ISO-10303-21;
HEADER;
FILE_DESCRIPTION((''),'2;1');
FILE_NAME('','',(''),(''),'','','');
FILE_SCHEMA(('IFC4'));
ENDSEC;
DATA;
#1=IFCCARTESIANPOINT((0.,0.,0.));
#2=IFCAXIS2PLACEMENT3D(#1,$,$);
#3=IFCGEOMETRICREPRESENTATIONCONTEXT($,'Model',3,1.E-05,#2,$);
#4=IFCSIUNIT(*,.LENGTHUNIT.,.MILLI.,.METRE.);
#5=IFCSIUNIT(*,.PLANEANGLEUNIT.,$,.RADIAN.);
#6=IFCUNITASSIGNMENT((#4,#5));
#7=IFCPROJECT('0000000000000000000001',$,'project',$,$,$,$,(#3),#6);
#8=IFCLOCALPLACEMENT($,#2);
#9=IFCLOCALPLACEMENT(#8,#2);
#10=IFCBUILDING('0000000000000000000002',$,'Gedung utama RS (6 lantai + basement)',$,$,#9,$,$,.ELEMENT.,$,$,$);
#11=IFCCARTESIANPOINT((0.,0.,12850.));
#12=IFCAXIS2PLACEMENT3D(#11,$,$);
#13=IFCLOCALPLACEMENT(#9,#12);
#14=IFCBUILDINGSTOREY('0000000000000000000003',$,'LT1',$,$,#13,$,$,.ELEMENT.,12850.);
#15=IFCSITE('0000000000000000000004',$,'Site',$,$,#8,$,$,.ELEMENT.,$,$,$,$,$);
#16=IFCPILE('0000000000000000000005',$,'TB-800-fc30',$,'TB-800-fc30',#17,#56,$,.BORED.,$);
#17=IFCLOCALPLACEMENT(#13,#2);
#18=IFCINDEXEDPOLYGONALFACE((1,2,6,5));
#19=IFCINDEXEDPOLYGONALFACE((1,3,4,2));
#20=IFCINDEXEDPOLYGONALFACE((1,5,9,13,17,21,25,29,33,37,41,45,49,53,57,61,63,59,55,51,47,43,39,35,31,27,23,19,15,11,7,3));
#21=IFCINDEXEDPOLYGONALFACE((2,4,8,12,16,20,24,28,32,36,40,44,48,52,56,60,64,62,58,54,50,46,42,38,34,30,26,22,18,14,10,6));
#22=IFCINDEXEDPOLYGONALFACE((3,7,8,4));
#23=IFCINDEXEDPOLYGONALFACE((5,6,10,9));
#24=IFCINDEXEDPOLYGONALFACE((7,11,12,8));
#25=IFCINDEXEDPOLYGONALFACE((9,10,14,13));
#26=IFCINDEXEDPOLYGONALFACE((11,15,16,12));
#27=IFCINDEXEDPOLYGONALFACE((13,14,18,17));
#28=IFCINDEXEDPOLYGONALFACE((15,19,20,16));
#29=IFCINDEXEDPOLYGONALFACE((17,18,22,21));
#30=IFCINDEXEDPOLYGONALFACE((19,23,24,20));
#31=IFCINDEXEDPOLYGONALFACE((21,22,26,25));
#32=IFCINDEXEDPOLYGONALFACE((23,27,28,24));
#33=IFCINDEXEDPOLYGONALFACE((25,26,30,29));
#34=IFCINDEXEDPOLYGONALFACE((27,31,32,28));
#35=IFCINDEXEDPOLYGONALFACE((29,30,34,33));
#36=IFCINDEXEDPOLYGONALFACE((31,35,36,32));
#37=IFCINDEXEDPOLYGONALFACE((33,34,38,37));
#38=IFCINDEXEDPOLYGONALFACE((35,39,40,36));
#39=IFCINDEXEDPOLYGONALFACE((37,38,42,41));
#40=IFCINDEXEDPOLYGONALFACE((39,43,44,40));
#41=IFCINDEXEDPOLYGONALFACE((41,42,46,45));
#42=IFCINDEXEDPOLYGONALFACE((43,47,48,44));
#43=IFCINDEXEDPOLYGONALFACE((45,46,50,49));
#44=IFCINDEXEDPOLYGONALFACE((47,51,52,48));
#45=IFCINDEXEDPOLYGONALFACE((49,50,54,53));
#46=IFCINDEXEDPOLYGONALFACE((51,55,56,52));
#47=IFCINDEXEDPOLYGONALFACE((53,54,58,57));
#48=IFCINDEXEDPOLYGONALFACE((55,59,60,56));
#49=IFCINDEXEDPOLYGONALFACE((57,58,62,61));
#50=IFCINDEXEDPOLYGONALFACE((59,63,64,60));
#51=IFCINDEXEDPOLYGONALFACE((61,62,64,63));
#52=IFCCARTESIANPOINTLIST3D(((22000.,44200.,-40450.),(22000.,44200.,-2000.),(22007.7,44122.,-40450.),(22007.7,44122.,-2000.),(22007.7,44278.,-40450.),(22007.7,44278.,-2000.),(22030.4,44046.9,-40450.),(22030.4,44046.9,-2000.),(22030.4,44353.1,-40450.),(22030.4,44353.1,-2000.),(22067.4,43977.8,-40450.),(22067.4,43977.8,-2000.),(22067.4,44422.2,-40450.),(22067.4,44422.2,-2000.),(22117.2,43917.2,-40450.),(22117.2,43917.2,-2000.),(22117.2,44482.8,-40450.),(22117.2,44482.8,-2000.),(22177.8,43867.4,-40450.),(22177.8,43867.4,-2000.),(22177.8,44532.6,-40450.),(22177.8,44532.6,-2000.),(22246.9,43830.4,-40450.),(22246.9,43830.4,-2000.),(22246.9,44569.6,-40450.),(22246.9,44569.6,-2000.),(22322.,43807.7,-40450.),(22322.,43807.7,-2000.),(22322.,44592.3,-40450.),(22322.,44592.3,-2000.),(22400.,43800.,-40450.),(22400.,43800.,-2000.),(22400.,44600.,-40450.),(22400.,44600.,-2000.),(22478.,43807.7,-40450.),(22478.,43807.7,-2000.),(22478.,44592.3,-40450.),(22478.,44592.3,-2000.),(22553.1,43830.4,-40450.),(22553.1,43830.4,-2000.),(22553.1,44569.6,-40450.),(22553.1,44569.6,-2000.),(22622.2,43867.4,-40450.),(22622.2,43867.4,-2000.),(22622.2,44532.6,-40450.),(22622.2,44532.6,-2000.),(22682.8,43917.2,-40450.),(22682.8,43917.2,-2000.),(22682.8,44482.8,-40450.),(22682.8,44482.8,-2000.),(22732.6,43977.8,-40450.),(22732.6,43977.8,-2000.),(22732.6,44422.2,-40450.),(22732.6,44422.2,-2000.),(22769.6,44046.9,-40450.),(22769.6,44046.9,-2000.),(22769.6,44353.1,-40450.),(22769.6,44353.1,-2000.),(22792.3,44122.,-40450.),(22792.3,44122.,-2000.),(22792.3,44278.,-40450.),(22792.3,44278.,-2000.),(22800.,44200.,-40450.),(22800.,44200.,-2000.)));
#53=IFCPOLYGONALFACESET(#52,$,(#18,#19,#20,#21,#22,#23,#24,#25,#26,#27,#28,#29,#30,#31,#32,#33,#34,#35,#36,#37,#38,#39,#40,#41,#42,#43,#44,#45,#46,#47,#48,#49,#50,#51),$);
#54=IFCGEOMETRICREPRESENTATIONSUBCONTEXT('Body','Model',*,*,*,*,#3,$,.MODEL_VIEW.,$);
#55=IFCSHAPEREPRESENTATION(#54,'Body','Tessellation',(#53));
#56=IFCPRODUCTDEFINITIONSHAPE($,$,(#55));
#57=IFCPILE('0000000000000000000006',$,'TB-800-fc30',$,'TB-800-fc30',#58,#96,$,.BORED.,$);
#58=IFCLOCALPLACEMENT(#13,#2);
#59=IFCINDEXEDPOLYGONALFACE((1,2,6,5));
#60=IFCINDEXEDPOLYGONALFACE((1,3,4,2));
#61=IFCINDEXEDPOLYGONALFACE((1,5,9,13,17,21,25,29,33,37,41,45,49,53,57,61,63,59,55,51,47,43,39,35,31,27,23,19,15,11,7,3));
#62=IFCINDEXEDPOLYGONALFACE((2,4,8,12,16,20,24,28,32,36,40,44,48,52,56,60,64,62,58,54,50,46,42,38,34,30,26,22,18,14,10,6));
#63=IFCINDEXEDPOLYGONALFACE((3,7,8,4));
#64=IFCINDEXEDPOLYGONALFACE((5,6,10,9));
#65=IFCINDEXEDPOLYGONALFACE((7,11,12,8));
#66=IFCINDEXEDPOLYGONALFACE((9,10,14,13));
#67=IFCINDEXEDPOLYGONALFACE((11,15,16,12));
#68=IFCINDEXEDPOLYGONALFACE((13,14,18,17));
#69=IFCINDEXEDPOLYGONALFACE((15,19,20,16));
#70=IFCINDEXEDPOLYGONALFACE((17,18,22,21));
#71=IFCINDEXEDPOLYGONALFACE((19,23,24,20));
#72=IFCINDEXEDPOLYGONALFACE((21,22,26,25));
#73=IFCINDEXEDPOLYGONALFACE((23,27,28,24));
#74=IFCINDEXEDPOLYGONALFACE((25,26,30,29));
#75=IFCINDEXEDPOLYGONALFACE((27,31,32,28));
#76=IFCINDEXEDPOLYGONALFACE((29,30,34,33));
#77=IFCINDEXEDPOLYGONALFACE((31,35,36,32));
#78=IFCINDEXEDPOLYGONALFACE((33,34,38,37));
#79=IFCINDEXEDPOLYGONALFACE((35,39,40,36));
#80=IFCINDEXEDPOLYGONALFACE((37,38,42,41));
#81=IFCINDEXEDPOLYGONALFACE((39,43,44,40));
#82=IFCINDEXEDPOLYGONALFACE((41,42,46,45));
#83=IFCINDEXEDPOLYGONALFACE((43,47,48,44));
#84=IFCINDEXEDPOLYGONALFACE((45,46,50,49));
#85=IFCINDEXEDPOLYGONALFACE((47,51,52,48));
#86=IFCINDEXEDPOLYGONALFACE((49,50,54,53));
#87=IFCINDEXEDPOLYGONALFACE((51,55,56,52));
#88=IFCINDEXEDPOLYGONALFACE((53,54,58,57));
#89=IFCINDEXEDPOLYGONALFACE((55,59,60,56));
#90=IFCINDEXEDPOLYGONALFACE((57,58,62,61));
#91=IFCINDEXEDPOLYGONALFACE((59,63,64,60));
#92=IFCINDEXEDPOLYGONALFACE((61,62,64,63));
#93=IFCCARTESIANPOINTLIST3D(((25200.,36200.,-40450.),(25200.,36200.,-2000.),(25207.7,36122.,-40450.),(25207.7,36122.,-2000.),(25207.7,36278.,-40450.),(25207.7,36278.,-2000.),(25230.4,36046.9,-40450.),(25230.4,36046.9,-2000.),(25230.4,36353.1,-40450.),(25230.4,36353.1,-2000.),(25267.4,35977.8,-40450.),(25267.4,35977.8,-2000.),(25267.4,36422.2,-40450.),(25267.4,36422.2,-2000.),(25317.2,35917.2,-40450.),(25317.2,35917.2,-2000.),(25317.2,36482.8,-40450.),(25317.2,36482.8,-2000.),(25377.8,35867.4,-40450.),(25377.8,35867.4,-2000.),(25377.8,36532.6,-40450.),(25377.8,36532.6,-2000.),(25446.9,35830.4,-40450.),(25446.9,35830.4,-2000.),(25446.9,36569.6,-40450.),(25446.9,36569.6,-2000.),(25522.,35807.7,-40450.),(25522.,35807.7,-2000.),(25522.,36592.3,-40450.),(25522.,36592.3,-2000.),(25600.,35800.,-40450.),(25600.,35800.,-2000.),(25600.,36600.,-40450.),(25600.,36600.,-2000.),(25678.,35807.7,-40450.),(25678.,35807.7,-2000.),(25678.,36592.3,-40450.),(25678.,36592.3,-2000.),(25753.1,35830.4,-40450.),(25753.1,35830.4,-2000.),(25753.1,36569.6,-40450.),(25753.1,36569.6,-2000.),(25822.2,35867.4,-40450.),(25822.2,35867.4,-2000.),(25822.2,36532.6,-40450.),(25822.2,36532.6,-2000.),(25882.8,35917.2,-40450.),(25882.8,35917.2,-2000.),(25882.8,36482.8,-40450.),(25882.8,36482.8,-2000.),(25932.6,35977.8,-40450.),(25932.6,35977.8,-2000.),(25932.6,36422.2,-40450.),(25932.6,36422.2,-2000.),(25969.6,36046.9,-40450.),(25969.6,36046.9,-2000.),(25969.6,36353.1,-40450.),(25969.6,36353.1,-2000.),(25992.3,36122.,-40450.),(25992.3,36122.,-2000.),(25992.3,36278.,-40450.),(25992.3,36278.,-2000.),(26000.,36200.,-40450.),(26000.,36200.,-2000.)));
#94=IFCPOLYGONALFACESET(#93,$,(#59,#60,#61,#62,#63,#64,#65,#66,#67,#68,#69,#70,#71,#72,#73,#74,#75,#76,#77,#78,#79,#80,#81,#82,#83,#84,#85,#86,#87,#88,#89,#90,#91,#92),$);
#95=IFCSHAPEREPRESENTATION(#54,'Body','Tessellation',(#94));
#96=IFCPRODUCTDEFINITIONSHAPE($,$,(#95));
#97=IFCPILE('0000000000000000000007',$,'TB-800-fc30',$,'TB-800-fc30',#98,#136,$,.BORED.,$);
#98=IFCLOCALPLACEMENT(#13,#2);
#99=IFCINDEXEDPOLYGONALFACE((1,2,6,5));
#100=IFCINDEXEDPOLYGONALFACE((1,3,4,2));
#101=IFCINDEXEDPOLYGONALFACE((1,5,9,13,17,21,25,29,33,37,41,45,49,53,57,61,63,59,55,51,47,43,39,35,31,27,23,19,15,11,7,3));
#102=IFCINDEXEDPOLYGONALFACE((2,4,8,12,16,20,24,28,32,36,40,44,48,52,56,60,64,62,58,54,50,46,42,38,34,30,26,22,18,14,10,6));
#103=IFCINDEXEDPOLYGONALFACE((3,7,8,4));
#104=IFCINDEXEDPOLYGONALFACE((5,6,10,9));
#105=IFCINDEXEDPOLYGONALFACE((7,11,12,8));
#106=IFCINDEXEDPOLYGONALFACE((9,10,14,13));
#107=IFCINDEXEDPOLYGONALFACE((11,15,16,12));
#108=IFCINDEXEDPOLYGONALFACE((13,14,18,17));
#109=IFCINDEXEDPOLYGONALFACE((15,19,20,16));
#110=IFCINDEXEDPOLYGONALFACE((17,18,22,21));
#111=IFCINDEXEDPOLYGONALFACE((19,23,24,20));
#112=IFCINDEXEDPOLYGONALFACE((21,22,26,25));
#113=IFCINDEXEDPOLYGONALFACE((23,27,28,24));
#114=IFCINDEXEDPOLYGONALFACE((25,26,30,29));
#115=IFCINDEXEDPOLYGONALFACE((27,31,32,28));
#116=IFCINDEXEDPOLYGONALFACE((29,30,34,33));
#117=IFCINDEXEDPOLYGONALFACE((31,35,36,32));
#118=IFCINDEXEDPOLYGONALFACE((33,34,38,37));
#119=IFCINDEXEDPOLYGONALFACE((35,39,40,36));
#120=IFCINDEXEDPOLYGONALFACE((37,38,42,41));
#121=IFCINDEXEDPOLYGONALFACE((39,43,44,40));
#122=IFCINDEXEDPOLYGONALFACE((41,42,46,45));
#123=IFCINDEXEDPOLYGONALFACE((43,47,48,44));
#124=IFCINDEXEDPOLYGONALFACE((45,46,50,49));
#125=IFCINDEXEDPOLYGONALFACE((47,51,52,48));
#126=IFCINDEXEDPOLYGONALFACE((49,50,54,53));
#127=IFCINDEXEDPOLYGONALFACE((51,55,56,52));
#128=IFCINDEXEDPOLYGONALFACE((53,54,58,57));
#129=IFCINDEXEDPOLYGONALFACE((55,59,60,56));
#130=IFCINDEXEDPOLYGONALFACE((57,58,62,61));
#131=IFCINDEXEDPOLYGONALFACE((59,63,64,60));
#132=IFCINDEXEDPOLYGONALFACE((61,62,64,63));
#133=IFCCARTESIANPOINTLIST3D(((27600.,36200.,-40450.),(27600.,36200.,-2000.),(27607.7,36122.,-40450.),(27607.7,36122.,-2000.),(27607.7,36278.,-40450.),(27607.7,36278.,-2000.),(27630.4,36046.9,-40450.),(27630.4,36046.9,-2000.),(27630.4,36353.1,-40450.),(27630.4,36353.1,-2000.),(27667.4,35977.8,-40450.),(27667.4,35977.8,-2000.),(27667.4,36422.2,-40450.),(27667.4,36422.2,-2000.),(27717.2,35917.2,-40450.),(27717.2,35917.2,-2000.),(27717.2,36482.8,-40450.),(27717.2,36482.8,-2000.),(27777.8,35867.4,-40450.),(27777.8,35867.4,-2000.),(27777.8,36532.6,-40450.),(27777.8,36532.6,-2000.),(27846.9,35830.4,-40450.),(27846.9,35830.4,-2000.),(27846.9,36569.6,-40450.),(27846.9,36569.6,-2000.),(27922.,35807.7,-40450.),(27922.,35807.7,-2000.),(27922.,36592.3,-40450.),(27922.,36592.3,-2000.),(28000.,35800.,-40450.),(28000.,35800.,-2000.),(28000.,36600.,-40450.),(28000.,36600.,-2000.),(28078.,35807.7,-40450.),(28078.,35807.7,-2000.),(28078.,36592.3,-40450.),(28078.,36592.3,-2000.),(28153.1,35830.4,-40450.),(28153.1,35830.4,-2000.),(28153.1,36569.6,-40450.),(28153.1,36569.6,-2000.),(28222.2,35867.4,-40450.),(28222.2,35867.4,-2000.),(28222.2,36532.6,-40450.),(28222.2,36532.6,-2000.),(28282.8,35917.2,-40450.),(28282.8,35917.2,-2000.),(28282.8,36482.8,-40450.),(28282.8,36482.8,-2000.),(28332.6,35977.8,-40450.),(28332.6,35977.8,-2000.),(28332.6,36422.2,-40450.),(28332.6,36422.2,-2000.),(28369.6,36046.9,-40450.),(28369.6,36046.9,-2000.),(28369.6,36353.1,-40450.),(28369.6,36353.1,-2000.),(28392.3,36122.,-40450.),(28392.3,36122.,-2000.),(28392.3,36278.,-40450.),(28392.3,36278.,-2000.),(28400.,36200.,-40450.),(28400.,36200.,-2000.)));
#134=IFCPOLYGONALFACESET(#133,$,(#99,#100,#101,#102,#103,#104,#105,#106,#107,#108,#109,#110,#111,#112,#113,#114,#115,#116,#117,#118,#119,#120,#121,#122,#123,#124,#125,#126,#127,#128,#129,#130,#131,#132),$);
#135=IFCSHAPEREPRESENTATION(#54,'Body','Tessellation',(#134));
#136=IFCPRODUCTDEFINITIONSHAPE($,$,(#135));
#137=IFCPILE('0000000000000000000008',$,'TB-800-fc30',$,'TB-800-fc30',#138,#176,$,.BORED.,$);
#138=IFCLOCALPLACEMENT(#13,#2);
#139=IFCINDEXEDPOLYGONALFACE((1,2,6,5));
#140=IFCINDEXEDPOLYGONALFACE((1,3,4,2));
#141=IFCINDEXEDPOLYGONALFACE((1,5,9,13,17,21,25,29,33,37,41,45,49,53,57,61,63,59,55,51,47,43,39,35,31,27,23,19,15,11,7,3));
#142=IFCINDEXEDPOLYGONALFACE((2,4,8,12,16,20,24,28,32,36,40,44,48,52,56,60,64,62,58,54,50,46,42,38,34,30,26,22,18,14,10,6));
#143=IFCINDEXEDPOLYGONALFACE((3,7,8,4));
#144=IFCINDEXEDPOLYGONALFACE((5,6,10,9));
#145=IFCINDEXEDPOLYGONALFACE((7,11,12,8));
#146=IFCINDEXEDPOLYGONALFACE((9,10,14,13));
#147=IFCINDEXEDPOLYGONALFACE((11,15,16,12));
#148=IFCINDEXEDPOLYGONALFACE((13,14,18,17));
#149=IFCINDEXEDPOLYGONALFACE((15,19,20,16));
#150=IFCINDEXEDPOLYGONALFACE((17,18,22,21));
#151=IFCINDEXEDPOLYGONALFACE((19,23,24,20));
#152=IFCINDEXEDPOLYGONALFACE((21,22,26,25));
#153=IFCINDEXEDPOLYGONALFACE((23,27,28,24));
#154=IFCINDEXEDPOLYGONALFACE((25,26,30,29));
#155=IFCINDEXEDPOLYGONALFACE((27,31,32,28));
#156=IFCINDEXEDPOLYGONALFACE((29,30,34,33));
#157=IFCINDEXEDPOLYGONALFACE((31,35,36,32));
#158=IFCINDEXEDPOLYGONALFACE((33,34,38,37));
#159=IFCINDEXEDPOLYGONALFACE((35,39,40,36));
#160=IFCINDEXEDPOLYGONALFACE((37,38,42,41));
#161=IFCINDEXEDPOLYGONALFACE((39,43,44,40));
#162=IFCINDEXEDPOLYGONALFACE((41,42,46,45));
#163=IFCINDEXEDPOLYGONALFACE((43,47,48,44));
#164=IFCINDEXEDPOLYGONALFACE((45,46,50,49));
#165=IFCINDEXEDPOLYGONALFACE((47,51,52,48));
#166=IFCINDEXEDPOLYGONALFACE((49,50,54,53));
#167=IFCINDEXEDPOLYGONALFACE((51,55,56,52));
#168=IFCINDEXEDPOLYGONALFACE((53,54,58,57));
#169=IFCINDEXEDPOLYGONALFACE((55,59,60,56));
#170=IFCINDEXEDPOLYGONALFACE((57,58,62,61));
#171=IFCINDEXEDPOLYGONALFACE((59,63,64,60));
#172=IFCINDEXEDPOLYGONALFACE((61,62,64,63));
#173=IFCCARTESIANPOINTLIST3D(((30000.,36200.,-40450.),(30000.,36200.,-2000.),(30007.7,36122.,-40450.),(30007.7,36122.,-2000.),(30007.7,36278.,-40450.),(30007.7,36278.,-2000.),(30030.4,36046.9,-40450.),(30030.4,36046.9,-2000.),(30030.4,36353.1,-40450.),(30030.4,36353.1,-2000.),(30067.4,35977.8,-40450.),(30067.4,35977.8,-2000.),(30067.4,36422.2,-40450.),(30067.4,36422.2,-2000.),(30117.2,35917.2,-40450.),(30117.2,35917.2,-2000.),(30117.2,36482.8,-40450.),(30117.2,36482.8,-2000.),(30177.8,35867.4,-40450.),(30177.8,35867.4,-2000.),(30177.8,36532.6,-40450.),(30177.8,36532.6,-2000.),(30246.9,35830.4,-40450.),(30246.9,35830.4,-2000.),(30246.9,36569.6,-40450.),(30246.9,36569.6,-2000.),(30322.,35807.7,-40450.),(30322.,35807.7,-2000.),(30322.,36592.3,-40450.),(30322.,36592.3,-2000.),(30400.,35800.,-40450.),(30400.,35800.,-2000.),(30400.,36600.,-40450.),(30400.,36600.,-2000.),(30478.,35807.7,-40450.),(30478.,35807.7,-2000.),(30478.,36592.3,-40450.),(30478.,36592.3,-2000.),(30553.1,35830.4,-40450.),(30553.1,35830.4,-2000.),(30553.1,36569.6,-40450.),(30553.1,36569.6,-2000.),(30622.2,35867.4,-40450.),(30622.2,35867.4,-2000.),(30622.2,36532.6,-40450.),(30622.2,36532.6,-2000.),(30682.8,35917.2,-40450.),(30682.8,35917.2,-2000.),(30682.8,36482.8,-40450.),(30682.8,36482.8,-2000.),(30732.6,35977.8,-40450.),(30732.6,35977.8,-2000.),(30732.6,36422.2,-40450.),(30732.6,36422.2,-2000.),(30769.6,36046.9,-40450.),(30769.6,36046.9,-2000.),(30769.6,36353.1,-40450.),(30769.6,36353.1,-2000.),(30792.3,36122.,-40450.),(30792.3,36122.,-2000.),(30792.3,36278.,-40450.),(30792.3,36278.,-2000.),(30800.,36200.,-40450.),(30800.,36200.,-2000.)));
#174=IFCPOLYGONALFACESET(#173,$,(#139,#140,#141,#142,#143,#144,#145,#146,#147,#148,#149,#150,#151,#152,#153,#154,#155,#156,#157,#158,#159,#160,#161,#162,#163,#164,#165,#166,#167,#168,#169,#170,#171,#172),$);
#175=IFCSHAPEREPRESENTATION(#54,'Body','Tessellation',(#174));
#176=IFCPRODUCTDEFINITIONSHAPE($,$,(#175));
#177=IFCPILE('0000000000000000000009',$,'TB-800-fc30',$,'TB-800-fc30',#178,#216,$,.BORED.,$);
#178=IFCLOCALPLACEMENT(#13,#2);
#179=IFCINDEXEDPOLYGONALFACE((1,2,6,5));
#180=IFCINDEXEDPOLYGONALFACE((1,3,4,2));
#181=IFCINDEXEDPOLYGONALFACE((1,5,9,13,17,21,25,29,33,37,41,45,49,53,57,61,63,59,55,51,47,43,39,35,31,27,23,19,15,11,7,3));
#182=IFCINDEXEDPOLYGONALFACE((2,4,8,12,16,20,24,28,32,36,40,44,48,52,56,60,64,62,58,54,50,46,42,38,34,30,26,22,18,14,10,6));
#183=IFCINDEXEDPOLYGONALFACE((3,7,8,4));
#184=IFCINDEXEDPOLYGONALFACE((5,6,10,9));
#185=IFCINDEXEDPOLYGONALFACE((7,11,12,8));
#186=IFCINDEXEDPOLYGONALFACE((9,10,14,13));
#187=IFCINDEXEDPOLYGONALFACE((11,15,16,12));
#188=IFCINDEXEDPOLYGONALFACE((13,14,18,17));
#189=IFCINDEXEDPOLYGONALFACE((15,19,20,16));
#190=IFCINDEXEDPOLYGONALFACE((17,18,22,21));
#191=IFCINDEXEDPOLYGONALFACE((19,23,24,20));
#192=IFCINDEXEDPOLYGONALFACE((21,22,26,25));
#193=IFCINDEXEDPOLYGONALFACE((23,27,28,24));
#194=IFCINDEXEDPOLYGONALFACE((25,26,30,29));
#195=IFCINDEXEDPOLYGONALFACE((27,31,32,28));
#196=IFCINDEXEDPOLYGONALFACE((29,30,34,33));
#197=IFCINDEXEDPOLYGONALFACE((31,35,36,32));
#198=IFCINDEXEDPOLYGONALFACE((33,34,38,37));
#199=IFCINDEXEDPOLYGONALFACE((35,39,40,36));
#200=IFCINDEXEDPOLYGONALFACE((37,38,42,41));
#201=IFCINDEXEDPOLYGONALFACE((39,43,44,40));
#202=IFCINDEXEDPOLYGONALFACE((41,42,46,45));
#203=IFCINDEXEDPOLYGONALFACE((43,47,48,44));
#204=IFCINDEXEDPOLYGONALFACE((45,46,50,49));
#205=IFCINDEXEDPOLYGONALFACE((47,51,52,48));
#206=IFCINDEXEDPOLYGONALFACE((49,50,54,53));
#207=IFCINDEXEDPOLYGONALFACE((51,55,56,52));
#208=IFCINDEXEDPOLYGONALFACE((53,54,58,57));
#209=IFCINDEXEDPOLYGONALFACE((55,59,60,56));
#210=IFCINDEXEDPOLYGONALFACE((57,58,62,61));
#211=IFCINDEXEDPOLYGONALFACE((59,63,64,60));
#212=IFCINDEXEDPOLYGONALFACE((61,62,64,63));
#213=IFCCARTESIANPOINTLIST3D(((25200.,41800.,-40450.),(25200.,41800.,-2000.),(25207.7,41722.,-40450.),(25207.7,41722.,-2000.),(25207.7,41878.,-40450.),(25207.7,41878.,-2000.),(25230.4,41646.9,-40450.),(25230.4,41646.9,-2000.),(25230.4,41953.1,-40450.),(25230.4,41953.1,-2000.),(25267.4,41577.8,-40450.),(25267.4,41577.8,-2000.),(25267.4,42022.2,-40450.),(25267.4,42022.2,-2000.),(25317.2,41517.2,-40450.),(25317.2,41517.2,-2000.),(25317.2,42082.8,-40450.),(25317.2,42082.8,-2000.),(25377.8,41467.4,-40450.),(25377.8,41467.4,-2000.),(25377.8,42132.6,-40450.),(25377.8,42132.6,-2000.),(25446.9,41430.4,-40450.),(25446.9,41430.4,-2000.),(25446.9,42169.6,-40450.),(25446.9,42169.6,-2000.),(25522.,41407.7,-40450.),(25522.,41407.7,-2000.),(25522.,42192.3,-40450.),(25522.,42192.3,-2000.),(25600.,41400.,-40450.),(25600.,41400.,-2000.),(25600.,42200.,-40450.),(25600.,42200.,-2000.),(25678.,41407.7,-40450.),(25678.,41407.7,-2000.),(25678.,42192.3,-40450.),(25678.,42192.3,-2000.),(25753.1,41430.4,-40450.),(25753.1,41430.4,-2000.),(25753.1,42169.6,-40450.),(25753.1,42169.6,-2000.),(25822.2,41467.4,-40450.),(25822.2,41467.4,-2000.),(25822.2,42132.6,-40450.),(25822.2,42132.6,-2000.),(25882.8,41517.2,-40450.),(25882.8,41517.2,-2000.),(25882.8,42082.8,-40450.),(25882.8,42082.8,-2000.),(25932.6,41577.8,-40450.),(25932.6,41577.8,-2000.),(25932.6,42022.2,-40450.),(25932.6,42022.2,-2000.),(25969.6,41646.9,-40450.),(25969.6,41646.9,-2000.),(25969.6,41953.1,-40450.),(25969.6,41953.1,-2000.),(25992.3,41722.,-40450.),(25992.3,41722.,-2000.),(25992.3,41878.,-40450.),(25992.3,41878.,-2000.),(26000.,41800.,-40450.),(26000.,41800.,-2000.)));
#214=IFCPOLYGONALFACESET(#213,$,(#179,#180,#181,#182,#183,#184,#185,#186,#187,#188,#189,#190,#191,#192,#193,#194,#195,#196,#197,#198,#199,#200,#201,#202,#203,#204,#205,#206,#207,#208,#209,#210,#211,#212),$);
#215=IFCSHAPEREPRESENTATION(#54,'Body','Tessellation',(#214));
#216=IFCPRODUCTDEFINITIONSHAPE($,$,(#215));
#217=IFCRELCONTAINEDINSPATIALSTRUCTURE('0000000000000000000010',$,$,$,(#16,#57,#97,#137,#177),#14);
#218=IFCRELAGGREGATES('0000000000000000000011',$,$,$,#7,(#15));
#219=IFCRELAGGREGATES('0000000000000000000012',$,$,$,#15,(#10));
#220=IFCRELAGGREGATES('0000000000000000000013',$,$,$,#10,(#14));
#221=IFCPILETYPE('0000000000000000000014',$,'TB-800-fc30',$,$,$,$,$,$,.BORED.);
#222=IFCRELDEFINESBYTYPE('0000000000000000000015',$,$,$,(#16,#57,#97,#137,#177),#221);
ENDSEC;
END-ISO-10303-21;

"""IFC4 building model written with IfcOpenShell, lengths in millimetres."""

from ifc_helpers import new_model, si_unit, frame, origin, origin_2d, place, context, subcontext, project, spatial, circle, extrude, material_profile, profile_set, profile_usage, type_object, element, save


model = new_model("IFC4")

# Units and contexts
model_context = context("Model", 3, precision=1e-05, world=origin())
body_context = subcontext(model_context, "Body", "Model", "MODEL_VIEW")
ifc_project = project(units=[si_unit("LENGTHUNIT", "METRE", prefix="MILLI"), si_unit("PLANEANGLEUNIT", "RADIAN")], contexts=[model_context])

# Site, building, storey
site_placement = place(None, origin())
site = spatial("IfcSite", under=ifc_project, at=site_placement, Name="Site", CompositionType="ELEMENT")
building_placement = place(site_placement, origin())
building = spatial("IfcBuilding", under=site, at=building_placement, Name="Gedung utama RS (6 lantai + basement)", CompositionType="ELEMENT")
storey_placement = place(building_placement, frame((0.0, 0.0, 12850.0)))
storey = spatial("IfcBuildingStorey", under=building, at=storey_placement, Name="LT1", CompositionType="ELEMENT", Elevation=12850.0)

# Piles
ifc_material_profile_1 = material_profile(None, circle(Radius=400.0, at=origin_2d()), Name="TB-800-fc30")
ifc_profile_set_1 = profile_set([ifc_material_profile_1], Name="TB-800-fc30")
ifc_profile_usage_1 = profile_usage(ifc_profile_set_1, cardinal=5)
pile_type = type_object("IfcPileType", Name="TB-800-fc30", PredefinedType="BORED", material=ifc_profile_set_1)
for number, where, z_axis, x_axis, name in (
    (1, (22400.0, 44200.0, -40450.0), (0.0, 0.0, 1.0), (1.0, 0.0, 0.0), "TB-800-fc30"),
    (2, (25600.0, 36200.0, -40450.0), (0.0, 0.0, 1.0), (1.0, 0.0, 0.0), "TB-800-fc30"),
    (3, (28000.0, 36200.0, -40450.0), (0.0, 0.0, 1.0), (1.0, 0.0, 0.0), "TB-800-fc30"),
    (4, (30400.0, 36200.0, -40450.0), (0.0, 0.0, 1.0), (1.0, 0.0, 0.0), "TB-800-fc30"),
    (5, (25600.0, 41800.0, -40450.0), (0.0, 0.0, 1.0), (1.0, 0.0, 0.0), "TB-800-fc30"),
):
    element("IfcPile", number, at=place(storey_placement, frame(where, z_axis=z_axis, x_axis=x_axis)), inside=storey, type_object=pile_type, material=ifc_profile_usage_1, Name=name, ObjectType="TB-800-fc30", PredefinedType="BORED", context=body_context, shape_type="SweptSolid", body=[
        extrude(circle(Radius=400.0, at=origin_2d()), origin(), (0.0, 0.0, 1.0), 38450.0),
    ])

save(model, "model.ifc")
